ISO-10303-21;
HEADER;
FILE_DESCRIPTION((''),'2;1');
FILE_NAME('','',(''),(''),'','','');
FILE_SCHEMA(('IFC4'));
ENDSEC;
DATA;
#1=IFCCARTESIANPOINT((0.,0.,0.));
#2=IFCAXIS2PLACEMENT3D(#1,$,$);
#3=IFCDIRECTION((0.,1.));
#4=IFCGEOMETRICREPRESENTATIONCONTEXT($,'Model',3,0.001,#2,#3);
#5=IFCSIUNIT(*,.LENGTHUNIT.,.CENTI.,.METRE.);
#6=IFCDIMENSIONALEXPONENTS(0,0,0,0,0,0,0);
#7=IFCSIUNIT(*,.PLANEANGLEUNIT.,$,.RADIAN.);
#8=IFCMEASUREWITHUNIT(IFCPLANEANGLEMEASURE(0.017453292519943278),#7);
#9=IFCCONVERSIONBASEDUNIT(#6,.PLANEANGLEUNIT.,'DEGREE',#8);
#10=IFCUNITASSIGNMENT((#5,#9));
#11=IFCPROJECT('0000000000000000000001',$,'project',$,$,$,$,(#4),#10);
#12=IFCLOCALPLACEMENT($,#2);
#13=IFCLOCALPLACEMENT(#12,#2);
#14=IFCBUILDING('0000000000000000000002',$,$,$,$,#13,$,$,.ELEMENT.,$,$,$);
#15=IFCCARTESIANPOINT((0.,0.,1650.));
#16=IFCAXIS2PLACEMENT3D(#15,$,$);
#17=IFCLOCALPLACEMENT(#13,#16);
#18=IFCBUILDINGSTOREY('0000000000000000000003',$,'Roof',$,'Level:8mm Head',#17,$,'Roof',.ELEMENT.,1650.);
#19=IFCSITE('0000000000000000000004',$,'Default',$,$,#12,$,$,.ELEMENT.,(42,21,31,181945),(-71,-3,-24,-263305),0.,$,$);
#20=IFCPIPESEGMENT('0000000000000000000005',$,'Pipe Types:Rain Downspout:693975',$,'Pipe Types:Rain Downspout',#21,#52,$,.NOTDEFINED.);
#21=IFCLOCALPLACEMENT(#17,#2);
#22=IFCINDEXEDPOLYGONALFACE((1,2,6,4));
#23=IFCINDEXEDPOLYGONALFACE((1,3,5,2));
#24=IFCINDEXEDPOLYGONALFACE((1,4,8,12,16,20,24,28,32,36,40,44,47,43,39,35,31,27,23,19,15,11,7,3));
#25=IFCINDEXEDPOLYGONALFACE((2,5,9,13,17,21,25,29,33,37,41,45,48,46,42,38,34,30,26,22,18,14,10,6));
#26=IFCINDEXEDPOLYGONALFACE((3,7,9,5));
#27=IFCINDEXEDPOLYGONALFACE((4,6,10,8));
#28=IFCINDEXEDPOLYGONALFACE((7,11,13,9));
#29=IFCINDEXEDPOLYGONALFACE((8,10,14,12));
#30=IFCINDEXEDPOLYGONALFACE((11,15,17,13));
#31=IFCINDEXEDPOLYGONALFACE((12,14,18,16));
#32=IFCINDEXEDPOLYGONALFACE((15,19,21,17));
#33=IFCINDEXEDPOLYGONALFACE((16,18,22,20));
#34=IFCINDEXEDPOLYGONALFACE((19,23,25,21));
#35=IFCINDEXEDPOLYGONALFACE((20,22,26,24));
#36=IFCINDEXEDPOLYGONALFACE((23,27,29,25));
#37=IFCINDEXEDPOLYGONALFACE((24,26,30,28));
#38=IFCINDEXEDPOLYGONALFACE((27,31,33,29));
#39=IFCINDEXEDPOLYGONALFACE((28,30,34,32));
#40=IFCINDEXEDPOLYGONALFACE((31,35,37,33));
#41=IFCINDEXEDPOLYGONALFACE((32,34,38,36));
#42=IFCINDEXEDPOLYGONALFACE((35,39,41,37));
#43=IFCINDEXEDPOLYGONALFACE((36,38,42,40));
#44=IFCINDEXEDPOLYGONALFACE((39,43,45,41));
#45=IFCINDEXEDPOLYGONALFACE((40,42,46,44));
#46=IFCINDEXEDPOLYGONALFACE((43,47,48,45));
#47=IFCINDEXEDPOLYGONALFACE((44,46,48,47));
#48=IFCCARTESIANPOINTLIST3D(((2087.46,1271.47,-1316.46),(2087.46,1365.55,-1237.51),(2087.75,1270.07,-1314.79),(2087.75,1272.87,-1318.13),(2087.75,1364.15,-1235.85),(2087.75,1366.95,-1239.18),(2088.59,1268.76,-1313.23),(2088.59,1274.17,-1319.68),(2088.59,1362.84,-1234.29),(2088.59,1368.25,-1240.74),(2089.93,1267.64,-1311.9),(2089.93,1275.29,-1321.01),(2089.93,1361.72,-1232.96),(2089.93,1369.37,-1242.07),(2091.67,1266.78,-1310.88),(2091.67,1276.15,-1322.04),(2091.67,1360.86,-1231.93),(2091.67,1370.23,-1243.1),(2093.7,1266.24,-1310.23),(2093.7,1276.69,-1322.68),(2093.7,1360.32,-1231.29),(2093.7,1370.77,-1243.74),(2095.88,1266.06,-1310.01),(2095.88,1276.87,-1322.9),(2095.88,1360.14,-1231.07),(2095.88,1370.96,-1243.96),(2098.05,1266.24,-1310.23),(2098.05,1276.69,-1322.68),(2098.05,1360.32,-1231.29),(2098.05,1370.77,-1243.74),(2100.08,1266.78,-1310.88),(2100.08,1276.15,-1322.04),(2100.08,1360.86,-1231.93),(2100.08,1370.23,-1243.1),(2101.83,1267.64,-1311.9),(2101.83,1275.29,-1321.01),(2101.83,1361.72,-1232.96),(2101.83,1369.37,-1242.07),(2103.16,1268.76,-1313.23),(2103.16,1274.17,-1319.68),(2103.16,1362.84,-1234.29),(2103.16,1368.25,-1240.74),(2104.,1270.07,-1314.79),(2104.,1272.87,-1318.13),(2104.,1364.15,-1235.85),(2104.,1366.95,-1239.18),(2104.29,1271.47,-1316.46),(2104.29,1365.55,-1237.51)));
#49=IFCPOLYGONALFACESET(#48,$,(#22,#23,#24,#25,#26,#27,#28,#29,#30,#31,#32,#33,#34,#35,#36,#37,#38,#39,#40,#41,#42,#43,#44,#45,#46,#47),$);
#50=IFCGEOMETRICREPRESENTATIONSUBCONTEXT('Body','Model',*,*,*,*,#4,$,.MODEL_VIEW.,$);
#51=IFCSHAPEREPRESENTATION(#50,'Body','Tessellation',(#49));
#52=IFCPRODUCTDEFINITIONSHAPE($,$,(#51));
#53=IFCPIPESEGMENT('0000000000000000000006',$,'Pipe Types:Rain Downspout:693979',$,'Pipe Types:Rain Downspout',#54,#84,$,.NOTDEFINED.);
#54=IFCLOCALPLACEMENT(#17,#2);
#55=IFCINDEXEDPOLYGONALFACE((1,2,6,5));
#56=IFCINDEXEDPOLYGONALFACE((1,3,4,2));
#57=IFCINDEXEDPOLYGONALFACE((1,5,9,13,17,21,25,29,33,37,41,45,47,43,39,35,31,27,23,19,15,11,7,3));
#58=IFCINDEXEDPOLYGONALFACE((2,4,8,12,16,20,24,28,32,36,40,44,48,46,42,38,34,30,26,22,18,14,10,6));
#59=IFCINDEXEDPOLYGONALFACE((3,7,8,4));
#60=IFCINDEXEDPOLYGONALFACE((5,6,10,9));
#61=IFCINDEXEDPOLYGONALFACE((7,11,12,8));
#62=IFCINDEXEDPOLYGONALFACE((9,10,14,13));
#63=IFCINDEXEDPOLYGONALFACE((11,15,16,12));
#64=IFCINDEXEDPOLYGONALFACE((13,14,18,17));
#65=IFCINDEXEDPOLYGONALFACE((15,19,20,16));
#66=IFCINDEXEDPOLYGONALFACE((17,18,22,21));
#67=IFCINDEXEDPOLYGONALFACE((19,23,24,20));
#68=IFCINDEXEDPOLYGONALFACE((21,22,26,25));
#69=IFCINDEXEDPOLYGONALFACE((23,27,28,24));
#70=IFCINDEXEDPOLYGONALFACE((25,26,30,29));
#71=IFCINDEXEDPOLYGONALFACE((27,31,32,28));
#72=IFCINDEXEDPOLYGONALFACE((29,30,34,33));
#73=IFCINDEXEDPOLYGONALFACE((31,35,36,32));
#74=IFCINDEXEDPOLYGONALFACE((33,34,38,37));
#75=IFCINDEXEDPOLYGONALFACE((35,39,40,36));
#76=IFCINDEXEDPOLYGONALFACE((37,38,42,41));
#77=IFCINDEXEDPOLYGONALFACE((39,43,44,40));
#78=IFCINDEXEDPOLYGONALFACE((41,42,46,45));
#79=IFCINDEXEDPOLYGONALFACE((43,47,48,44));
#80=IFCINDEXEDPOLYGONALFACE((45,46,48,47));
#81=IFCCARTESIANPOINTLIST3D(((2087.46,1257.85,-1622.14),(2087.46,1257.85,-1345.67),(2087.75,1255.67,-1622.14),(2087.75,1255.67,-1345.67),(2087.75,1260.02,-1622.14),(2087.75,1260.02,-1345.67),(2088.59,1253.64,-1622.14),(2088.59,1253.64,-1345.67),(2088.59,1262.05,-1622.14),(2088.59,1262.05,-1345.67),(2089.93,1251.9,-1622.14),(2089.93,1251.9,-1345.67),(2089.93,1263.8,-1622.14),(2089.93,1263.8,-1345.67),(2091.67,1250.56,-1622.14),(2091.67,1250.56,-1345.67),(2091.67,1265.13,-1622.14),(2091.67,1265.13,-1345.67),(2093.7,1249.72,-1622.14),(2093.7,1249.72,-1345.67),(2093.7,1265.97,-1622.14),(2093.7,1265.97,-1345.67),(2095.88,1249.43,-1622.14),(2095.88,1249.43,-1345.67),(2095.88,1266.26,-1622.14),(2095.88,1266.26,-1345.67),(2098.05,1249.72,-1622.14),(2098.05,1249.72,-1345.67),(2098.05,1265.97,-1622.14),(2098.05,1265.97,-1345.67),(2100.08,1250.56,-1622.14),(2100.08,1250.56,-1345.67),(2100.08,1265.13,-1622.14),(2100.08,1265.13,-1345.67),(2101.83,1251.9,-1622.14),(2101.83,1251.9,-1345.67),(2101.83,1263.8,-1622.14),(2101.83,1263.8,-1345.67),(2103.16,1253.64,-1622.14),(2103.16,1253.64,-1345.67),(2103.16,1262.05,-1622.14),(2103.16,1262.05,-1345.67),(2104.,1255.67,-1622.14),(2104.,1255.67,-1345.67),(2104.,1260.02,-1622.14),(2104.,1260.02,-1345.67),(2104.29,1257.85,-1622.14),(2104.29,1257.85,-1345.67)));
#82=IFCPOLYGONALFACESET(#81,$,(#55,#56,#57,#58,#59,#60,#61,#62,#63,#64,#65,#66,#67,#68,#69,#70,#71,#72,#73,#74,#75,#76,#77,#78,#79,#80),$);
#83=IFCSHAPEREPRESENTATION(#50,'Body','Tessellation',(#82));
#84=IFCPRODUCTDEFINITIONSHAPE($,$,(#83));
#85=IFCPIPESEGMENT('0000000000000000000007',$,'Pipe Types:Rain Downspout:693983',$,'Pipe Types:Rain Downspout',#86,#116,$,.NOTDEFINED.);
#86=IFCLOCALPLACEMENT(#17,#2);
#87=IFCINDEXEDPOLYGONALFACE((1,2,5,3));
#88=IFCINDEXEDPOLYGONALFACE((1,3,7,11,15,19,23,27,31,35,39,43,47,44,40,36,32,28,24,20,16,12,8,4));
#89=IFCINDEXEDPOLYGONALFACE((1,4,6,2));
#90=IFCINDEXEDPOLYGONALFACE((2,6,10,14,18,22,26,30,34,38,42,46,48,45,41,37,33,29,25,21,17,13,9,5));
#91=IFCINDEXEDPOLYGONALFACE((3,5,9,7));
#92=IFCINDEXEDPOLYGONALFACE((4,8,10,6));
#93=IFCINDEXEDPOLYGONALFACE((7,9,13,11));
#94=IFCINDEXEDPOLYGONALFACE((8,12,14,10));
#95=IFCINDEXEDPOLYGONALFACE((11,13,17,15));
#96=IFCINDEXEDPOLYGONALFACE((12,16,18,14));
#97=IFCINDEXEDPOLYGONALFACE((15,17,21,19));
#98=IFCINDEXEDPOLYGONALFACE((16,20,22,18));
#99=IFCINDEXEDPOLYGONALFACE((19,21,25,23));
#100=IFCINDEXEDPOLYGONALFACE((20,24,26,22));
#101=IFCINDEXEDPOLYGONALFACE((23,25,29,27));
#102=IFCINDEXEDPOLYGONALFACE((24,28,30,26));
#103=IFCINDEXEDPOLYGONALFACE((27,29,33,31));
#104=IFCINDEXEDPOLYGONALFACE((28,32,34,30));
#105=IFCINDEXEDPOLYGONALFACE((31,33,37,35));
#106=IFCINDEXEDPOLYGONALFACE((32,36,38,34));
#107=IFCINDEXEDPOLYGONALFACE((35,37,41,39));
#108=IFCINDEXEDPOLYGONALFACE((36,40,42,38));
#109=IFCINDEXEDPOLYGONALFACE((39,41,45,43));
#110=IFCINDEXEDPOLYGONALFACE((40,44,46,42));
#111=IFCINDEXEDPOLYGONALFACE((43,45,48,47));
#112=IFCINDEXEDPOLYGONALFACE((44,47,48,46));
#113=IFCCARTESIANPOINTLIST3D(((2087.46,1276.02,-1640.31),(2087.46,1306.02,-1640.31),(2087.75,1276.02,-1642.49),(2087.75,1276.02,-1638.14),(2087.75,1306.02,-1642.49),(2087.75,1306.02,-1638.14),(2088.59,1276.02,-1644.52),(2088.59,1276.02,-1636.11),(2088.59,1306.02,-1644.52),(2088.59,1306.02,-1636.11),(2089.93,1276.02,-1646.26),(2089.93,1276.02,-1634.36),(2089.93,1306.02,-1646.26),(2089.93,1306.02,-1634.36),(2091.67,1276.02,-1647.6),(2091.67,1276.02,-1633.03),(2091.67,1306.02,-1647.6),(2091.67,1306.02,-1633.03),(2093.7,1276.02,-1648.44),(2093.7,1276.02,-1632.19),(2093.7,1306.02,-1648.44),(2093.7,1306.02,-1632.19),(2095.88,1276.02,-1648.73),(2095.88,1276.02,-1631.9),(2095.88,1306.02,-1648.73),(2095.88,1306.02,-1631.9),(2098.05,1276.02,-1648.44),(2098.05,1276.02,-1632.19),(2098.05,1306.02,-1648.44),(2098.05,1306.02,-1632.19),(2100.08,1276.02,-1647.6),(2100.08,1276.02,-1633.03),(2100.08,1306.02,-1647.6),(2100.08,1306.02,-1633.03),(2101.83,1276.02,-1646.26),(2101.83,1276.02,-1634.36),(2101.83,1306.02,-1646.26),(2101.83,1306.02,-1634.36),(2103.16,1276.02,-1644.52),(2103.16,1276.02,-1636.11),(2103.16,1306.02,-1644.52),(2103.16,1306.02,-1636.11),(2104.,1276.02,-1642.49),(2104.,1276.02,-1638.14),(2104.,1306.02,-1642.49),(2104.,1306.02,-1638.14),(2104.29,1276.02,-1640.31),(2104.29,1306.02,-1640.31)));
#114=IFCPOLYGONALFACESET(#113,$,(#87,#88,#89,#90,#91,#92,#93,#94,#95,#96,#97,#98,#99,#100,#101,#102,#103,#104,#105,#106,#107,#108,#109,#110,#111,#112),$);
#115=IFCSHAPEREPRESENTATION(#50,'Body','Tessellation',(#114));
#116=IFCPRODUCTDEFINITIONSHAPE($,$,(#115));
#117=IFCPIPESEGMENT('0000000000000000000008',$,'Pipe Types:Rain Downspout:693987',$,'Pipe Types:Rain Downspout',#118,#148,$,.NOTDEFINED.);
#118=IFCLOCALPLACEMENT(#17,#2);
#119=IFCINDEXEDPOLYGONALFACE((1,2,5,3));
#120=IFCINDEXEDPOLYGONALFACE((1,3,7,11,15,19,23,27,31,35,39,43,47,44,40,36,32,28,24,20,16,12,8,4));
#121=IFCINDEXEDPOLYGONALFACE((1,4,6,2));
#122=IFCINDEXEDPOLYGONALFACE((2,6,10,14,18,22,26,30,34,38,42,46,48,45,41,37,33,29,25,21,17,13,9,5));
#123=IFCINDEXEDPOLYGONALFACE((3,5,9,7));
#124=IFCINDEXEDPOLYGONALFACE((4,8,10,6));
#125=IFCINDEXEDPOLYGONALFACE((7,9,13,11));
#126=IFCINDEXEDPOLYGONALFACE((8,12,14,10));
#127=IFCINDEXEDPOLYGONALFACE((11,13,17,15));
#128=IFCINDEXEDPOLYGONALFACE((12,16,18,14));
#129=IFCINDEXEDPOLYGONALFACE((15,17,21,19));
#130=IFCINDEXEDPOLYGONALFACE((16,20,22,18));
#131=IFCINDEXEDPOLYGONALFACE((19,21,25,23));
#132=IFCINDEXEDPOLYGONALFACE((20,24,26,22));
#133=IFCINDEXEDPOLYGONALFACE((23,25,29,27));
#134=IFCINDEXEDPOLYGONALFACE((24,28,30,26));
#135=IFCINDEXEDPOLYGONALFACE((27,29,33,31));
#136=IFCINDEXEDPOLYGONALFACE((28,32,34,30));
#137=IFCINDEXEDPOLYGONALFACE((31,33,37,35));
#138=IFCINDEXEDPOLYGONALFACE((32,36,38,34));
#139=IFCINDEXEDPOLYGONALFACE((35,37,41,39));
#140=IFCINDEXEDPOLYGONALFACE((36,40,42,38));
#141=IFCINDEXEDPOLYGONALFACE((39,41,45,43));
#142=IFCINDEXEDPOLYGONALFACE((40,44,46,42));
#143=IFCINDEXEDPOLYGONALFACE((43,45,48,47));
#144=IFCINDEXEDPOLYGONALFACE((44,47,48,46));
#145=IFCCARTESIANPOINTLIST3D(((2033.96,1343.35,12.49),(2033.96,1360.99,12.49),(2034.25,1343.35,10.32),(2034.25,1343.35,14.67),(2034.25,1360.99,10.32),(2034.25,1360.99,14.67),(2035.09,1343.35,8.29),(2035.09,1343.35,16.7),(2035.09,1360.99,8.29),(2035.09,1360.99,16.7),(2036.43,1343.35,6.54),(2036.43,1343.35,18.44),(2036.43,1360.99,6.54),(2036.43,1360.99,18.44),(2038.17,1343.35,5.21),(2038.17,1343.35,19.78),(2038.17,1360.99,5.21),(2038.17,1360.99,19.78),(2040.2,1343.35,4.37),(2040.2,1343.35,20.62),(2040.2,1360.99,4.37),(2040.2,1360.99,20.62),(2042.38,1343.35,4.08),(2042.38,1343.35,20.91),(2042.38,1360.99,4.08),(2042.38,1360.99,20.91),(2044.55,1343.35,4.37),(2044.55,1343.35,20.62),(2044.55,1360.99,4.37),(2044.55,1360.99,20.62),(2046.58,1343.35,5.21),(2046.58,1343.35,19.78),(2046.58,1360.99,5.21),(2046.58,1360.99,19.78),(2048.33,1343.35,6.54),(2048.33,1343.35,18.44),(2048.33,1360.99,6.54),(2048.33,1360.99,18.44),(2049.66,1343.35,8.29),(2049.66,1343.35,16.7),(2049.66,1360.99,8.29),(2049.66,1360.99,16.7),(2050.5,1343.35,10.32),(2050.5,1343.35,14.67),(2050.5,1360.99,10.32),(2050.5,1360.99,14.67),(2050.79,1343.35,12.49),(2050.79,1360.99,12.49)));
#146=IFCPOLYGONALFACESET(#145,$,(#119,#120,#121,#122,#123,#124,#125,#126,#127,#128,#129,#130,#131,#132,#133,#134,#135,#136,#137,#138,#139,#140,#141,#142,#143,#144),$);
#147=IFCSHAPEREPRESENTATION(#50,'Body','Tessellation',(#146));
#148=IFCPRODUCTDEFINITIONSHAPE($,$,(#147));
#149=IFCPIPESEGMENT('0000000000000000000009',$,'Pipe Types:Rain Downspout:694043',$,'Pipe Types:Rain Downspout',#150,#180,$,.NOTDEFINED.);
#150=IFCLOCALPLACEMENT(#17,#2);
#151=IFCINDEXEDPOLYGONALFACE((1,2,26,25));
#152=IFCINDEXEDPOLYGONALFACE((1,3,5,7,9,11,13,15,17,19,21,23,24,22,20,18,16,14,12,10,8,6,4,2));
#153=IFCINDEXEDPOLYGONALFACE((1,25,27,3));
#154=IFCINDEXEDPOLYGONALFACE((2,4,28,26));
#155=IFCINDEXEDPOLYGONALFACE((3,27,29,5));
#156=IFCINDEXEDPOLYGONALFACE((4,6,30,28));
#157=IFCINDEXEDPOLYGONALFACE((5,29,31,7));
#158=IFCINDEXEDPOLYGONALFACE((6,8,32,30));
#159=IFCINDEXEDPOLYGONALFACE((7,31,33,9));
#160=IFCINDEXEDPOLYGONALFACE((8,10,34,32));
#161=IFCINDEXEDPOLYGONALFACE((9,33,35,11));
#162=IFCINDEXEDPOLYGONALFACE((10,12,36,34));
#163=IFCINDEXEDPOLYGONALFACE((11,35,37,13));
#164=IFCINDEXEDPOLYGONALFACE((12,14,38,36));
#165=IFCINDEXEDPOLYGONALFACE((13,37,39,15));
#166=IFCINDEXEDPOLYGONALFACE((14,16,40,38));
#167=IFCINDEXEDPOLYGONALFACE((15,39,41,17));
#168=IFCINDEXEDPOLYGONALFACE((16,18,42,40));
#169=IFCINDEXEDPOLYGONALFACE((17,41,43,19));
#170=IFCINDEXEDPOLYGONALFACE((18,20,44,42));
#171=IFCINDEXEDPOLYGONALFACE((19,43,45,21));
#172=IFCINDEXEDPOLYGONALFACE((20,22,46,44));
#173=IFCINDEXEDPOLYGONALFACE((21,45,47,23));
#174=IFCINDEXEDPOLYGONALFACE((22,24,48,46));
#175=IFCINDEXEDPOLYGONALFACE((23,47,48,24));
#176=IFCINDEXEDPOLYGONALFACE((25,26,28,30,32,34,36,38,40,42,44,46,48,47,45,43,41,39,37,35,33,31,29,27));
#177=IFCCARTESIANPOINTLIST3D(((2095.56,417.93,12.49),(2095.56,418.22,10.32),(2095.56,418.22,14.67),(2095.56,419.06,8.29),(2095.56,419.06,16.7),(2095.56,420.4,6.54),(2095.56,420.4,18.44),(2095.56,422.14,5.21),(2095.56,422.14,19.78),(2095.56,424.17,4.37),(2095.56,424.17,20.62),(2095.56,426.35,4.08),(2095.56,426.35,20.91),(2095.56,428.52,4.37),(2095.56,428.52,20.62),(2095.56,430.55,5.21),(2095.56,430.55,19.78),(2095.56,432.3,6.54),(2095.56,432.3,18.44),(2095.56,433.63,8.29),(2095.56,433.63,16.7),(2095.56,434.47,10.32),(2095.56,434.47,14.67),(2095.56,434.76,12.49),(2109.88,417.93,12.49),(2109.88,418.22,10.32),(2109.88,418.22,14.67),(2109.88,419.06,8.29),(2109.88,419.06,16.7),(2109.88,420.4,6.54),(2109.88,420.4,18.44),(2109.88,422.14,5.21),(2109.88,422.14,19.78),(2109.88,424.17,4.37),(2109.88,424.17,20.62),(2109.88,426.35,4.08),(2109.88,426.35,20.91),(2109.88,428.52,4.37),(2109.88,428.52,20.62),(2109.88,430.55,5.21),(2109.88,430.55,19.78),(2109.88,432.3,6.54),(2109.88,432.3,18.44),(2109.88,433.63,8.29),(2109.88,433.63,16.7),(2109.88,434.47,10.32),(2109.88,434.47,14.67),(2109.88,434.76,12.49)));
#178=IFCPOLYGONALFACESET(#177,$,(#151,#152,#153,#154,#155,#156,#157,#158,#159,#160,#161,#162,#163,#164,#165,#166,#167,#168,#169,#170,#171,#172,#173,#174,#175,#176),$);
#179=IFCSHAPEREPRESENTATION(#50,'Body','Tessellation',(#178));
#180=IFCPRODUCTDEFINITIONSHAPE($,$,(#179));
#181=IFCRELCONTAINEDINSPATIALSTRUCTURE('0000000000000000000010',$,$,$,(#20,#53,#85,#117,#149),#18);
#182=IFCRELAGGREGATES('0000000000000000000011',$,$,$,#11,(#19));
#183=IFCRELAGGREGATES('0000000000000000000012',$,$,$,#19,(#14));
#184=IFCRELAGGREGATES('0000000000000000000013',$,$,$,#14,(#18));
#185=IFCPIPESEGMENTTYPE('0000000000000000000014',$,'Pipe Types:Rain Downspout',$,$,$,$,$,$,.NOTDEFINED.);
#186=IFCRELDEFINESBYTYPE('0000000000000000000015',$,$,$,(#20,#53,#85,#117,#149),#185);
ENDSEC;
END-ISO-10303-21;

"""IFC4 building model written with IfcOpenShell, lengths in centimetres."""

from ifc_helpers import new_model, entity, si_unit, converted_unit, direction, frame, origin, place, context, subcontext, project, spatial, arc, indexed_curve, outline, extrude, type_object, element, save


model = new_model("IFC4")

# Units and contexts
model_context = context("Model", 3, precision=0.001, world=origin(), true_north=direction((0.0, 1.0)))
body_context = subcontext(model_context, "Body", "Model", "MODEL_VIEW")
ifc_project = project(units=[si_unit("LENGTHUNIT", "METRE", prefix="CENTI"), converted_unit("PLANEANGLEUNIT", "DEGREE", entity("IfcPlaneAngleMeasure", 0.017453292519943278), si_unit("PLANEANGLEUNIT", "RADIAN"), dimensions=[0, 0, 0, 0, 0, 0, 0])], contexts=[model_context])

# Site, building, storey
site_placement = place(None, origin())
site = spatial("IfcSite", under=ifc_project, at=site_placement, Name="Default", CompositionType="ELEMENT", RefLatitude=(42, 21, 31, 181945), RefLongitude=(-71, -3, -24, -263305), RefElevation=0.0)
building_placement = place(site_placement, origin())
building = spatial("IfcBuilding", under=site, at=building_placement, CompositionType="ELEMENT")
storey_placement = place(building_placement, frame((0.0, 0.0, 1650.0)))
storey = spatial("IfcBuildingStorey", under=building, at=storey_placement, Name="Roof", ObjectType="Level:8mm Head", LongName="Roof", CompositionType="ELEMENT", Elevation=1650.0)

# Pipe segments
pipe_segment_type = type_object("IfcPipeSegmentType", Name="Pipe Types:Rain Downspout", PredefinedType="NOTDEFINED")
pipe_segment_1_placement = place(storey_placement, origin())
element("IfcPipeSegment", 1, at=pipe_segment_1_placement, inside=storey, type_object=pipe_segment_type, Name="Pipe Types:Rain Downspout:693975", ObjectType="Pipe Types:Rain Downspout", PredefinedType="NOTDEFINED", context=body_context, shape_type="SweptSolid", body=[
    extrude(outline(indexed_curve([(8.41, 0.0), (5.95, 5.95), (0.0, 8.41), (-5.95, 5.95), (-8.41, 0.0), (-5.95, -5.95), (0.0, -8.41), (5.95, -5.95)], segments=[arc(1, 2, 3), arc(3, 4, 5), arc(5, 6, 7), arc(7, 8, 1)], self_intersect=False)), frame((2095.88, 1271.47, -1316.46), z_axis=(0.0, 0.766044, 0.642788), x_axis=(-1.0, 0.0, 0.0)), (0.0, 0.0, 1.0), 122.81),
])
pipe_segment_2_placement = place(storey_placement, origin())
element("IfcPipeSegment", 2, at=pipe_segment_2_placement, inside=storey, type_object=pipe_segment_type, Name="Pipe Types:Rain Downspout:693979", ObjectType="Pipe Types:Rain Downspout", PredefinedType="NOTDEFINED", context=body_context, shape_type="SweptSolid", body=[
    extrude(outline(indexed_curve([(8.41, 0.0), (5.95, 5.95), (0.0, 8.41), (-5.95, 5.95), (-8.41, 0.0), (-5.95, -5.95), (0.0, -8.41), (5.95, -5.95)], segments=[arc(1, 2, 3), arc(3, 4, 5), arc(5, 6, 7), arc(7, 8, 1)], self_intersect=False)), frame((2095.88, 1257.85, -1622.14)), (0.0, 0.0, 1.0), 276.47),
])
pipe_segment_3_placement = place(storey_placement, origin())
element("IfcPipeSegment", 3, at=pipe_segment_3_placement, inside=storey, type_object=pipe_segment_type, Name="Pipe Types:Rain Downspout:693983", ObjectType="Pipe Types:Rain Downspout", PredefinedType="NOTDEFINED", context=body_context, shape_type="SweptSolid", body=[
    extrude(outline(indexed_curve([(8.41, 0.0), (5.95, 5.95), (0.0, 8.41), (-5.95, 5.95), (-8.41, 0.0), (-5.95, -5.95), (0.0, -8.41), (5.95, -5.95)], segments=[arc(1, 2, 3), arc(3, 4, 5), arc(5, 6, 7), arc(7, 8, 1)], self_intersect=False)), frame((2095.88, 1276.02, -1640.31), z_axis=(0.0, 1.0, 0.0), x_axis=(1.0, 0.0, 0.0)), (0.0, 0.0, 1.0), 30.0),
])
pipe_segment_4_placement = place(storey_placement, origin())
element("IfcPipeSegment", 4, at=pipe_segment_4_placement, inside=storey, type_object=pipe_segment_type, Name="Pipe Types:Rain Downspout:693987", ObjectType="Pipe Types:Rain Downspout", PredefinedType="NOTDEFINED", context=body_context, shape_type="SweptSolid", body=[
    extrude(outline(indexed_curve([(8.41, 0.0), (5.95, 5.95), (0.0, 8.41), (-5.95, 5.95), (-8.41, 0.0), (-5.95, -5.95), (0.0, -8.41), (5.95, -5.95)], segments=[arc(1, 2, 3), arc(3, 4, 5), arc(5, 6, 7), arc(7, 8, 1)], self_intersect=False)), frame((2042.38, 1343.35, 12.49), z_axis=(0.0, 1.0, 0.0), x_axis=(-1.0, 0.0, 0.0)), (0.0, 0.0, 1.0), 17.65),
])
pipe_segment_5_placement = place(storey_placement, origin())
element("IfcPipeSegment", 5, at=pipe_segment_5_placement, inside=storey, type_object=pipe_segment_type, Name="Pipe Types:Rain Downspout:694043", ObjectType="Pipe Types:Rain Downspout", PredefinedType="NOTDEFINED", context=body_context, shape_type="SweptSolid", body=[
    extrude(outline(indexed_curve([(8.41, 0.0), (5.95, 5.95), (0.0, 8.41), (-5.95, 5.95), (-8.41, 0.0), (-5.95, -5.95), (0.0, -8.41), (5.95, -5.95)], segments=[arc(1, 2, 3), arc(3, 4, 5), arc(5, 6, 7), arc(7, 8, 1)], self_intersect=False)), frame((2095.56, 426.35, 12.49), z_axis=(1.0, 0.0, 0.0), x_axis=(0.0, 1.0, 0.0)), (0.0, 0.0, 1.0), 14.32),
])

save(model, "model.ifc")
